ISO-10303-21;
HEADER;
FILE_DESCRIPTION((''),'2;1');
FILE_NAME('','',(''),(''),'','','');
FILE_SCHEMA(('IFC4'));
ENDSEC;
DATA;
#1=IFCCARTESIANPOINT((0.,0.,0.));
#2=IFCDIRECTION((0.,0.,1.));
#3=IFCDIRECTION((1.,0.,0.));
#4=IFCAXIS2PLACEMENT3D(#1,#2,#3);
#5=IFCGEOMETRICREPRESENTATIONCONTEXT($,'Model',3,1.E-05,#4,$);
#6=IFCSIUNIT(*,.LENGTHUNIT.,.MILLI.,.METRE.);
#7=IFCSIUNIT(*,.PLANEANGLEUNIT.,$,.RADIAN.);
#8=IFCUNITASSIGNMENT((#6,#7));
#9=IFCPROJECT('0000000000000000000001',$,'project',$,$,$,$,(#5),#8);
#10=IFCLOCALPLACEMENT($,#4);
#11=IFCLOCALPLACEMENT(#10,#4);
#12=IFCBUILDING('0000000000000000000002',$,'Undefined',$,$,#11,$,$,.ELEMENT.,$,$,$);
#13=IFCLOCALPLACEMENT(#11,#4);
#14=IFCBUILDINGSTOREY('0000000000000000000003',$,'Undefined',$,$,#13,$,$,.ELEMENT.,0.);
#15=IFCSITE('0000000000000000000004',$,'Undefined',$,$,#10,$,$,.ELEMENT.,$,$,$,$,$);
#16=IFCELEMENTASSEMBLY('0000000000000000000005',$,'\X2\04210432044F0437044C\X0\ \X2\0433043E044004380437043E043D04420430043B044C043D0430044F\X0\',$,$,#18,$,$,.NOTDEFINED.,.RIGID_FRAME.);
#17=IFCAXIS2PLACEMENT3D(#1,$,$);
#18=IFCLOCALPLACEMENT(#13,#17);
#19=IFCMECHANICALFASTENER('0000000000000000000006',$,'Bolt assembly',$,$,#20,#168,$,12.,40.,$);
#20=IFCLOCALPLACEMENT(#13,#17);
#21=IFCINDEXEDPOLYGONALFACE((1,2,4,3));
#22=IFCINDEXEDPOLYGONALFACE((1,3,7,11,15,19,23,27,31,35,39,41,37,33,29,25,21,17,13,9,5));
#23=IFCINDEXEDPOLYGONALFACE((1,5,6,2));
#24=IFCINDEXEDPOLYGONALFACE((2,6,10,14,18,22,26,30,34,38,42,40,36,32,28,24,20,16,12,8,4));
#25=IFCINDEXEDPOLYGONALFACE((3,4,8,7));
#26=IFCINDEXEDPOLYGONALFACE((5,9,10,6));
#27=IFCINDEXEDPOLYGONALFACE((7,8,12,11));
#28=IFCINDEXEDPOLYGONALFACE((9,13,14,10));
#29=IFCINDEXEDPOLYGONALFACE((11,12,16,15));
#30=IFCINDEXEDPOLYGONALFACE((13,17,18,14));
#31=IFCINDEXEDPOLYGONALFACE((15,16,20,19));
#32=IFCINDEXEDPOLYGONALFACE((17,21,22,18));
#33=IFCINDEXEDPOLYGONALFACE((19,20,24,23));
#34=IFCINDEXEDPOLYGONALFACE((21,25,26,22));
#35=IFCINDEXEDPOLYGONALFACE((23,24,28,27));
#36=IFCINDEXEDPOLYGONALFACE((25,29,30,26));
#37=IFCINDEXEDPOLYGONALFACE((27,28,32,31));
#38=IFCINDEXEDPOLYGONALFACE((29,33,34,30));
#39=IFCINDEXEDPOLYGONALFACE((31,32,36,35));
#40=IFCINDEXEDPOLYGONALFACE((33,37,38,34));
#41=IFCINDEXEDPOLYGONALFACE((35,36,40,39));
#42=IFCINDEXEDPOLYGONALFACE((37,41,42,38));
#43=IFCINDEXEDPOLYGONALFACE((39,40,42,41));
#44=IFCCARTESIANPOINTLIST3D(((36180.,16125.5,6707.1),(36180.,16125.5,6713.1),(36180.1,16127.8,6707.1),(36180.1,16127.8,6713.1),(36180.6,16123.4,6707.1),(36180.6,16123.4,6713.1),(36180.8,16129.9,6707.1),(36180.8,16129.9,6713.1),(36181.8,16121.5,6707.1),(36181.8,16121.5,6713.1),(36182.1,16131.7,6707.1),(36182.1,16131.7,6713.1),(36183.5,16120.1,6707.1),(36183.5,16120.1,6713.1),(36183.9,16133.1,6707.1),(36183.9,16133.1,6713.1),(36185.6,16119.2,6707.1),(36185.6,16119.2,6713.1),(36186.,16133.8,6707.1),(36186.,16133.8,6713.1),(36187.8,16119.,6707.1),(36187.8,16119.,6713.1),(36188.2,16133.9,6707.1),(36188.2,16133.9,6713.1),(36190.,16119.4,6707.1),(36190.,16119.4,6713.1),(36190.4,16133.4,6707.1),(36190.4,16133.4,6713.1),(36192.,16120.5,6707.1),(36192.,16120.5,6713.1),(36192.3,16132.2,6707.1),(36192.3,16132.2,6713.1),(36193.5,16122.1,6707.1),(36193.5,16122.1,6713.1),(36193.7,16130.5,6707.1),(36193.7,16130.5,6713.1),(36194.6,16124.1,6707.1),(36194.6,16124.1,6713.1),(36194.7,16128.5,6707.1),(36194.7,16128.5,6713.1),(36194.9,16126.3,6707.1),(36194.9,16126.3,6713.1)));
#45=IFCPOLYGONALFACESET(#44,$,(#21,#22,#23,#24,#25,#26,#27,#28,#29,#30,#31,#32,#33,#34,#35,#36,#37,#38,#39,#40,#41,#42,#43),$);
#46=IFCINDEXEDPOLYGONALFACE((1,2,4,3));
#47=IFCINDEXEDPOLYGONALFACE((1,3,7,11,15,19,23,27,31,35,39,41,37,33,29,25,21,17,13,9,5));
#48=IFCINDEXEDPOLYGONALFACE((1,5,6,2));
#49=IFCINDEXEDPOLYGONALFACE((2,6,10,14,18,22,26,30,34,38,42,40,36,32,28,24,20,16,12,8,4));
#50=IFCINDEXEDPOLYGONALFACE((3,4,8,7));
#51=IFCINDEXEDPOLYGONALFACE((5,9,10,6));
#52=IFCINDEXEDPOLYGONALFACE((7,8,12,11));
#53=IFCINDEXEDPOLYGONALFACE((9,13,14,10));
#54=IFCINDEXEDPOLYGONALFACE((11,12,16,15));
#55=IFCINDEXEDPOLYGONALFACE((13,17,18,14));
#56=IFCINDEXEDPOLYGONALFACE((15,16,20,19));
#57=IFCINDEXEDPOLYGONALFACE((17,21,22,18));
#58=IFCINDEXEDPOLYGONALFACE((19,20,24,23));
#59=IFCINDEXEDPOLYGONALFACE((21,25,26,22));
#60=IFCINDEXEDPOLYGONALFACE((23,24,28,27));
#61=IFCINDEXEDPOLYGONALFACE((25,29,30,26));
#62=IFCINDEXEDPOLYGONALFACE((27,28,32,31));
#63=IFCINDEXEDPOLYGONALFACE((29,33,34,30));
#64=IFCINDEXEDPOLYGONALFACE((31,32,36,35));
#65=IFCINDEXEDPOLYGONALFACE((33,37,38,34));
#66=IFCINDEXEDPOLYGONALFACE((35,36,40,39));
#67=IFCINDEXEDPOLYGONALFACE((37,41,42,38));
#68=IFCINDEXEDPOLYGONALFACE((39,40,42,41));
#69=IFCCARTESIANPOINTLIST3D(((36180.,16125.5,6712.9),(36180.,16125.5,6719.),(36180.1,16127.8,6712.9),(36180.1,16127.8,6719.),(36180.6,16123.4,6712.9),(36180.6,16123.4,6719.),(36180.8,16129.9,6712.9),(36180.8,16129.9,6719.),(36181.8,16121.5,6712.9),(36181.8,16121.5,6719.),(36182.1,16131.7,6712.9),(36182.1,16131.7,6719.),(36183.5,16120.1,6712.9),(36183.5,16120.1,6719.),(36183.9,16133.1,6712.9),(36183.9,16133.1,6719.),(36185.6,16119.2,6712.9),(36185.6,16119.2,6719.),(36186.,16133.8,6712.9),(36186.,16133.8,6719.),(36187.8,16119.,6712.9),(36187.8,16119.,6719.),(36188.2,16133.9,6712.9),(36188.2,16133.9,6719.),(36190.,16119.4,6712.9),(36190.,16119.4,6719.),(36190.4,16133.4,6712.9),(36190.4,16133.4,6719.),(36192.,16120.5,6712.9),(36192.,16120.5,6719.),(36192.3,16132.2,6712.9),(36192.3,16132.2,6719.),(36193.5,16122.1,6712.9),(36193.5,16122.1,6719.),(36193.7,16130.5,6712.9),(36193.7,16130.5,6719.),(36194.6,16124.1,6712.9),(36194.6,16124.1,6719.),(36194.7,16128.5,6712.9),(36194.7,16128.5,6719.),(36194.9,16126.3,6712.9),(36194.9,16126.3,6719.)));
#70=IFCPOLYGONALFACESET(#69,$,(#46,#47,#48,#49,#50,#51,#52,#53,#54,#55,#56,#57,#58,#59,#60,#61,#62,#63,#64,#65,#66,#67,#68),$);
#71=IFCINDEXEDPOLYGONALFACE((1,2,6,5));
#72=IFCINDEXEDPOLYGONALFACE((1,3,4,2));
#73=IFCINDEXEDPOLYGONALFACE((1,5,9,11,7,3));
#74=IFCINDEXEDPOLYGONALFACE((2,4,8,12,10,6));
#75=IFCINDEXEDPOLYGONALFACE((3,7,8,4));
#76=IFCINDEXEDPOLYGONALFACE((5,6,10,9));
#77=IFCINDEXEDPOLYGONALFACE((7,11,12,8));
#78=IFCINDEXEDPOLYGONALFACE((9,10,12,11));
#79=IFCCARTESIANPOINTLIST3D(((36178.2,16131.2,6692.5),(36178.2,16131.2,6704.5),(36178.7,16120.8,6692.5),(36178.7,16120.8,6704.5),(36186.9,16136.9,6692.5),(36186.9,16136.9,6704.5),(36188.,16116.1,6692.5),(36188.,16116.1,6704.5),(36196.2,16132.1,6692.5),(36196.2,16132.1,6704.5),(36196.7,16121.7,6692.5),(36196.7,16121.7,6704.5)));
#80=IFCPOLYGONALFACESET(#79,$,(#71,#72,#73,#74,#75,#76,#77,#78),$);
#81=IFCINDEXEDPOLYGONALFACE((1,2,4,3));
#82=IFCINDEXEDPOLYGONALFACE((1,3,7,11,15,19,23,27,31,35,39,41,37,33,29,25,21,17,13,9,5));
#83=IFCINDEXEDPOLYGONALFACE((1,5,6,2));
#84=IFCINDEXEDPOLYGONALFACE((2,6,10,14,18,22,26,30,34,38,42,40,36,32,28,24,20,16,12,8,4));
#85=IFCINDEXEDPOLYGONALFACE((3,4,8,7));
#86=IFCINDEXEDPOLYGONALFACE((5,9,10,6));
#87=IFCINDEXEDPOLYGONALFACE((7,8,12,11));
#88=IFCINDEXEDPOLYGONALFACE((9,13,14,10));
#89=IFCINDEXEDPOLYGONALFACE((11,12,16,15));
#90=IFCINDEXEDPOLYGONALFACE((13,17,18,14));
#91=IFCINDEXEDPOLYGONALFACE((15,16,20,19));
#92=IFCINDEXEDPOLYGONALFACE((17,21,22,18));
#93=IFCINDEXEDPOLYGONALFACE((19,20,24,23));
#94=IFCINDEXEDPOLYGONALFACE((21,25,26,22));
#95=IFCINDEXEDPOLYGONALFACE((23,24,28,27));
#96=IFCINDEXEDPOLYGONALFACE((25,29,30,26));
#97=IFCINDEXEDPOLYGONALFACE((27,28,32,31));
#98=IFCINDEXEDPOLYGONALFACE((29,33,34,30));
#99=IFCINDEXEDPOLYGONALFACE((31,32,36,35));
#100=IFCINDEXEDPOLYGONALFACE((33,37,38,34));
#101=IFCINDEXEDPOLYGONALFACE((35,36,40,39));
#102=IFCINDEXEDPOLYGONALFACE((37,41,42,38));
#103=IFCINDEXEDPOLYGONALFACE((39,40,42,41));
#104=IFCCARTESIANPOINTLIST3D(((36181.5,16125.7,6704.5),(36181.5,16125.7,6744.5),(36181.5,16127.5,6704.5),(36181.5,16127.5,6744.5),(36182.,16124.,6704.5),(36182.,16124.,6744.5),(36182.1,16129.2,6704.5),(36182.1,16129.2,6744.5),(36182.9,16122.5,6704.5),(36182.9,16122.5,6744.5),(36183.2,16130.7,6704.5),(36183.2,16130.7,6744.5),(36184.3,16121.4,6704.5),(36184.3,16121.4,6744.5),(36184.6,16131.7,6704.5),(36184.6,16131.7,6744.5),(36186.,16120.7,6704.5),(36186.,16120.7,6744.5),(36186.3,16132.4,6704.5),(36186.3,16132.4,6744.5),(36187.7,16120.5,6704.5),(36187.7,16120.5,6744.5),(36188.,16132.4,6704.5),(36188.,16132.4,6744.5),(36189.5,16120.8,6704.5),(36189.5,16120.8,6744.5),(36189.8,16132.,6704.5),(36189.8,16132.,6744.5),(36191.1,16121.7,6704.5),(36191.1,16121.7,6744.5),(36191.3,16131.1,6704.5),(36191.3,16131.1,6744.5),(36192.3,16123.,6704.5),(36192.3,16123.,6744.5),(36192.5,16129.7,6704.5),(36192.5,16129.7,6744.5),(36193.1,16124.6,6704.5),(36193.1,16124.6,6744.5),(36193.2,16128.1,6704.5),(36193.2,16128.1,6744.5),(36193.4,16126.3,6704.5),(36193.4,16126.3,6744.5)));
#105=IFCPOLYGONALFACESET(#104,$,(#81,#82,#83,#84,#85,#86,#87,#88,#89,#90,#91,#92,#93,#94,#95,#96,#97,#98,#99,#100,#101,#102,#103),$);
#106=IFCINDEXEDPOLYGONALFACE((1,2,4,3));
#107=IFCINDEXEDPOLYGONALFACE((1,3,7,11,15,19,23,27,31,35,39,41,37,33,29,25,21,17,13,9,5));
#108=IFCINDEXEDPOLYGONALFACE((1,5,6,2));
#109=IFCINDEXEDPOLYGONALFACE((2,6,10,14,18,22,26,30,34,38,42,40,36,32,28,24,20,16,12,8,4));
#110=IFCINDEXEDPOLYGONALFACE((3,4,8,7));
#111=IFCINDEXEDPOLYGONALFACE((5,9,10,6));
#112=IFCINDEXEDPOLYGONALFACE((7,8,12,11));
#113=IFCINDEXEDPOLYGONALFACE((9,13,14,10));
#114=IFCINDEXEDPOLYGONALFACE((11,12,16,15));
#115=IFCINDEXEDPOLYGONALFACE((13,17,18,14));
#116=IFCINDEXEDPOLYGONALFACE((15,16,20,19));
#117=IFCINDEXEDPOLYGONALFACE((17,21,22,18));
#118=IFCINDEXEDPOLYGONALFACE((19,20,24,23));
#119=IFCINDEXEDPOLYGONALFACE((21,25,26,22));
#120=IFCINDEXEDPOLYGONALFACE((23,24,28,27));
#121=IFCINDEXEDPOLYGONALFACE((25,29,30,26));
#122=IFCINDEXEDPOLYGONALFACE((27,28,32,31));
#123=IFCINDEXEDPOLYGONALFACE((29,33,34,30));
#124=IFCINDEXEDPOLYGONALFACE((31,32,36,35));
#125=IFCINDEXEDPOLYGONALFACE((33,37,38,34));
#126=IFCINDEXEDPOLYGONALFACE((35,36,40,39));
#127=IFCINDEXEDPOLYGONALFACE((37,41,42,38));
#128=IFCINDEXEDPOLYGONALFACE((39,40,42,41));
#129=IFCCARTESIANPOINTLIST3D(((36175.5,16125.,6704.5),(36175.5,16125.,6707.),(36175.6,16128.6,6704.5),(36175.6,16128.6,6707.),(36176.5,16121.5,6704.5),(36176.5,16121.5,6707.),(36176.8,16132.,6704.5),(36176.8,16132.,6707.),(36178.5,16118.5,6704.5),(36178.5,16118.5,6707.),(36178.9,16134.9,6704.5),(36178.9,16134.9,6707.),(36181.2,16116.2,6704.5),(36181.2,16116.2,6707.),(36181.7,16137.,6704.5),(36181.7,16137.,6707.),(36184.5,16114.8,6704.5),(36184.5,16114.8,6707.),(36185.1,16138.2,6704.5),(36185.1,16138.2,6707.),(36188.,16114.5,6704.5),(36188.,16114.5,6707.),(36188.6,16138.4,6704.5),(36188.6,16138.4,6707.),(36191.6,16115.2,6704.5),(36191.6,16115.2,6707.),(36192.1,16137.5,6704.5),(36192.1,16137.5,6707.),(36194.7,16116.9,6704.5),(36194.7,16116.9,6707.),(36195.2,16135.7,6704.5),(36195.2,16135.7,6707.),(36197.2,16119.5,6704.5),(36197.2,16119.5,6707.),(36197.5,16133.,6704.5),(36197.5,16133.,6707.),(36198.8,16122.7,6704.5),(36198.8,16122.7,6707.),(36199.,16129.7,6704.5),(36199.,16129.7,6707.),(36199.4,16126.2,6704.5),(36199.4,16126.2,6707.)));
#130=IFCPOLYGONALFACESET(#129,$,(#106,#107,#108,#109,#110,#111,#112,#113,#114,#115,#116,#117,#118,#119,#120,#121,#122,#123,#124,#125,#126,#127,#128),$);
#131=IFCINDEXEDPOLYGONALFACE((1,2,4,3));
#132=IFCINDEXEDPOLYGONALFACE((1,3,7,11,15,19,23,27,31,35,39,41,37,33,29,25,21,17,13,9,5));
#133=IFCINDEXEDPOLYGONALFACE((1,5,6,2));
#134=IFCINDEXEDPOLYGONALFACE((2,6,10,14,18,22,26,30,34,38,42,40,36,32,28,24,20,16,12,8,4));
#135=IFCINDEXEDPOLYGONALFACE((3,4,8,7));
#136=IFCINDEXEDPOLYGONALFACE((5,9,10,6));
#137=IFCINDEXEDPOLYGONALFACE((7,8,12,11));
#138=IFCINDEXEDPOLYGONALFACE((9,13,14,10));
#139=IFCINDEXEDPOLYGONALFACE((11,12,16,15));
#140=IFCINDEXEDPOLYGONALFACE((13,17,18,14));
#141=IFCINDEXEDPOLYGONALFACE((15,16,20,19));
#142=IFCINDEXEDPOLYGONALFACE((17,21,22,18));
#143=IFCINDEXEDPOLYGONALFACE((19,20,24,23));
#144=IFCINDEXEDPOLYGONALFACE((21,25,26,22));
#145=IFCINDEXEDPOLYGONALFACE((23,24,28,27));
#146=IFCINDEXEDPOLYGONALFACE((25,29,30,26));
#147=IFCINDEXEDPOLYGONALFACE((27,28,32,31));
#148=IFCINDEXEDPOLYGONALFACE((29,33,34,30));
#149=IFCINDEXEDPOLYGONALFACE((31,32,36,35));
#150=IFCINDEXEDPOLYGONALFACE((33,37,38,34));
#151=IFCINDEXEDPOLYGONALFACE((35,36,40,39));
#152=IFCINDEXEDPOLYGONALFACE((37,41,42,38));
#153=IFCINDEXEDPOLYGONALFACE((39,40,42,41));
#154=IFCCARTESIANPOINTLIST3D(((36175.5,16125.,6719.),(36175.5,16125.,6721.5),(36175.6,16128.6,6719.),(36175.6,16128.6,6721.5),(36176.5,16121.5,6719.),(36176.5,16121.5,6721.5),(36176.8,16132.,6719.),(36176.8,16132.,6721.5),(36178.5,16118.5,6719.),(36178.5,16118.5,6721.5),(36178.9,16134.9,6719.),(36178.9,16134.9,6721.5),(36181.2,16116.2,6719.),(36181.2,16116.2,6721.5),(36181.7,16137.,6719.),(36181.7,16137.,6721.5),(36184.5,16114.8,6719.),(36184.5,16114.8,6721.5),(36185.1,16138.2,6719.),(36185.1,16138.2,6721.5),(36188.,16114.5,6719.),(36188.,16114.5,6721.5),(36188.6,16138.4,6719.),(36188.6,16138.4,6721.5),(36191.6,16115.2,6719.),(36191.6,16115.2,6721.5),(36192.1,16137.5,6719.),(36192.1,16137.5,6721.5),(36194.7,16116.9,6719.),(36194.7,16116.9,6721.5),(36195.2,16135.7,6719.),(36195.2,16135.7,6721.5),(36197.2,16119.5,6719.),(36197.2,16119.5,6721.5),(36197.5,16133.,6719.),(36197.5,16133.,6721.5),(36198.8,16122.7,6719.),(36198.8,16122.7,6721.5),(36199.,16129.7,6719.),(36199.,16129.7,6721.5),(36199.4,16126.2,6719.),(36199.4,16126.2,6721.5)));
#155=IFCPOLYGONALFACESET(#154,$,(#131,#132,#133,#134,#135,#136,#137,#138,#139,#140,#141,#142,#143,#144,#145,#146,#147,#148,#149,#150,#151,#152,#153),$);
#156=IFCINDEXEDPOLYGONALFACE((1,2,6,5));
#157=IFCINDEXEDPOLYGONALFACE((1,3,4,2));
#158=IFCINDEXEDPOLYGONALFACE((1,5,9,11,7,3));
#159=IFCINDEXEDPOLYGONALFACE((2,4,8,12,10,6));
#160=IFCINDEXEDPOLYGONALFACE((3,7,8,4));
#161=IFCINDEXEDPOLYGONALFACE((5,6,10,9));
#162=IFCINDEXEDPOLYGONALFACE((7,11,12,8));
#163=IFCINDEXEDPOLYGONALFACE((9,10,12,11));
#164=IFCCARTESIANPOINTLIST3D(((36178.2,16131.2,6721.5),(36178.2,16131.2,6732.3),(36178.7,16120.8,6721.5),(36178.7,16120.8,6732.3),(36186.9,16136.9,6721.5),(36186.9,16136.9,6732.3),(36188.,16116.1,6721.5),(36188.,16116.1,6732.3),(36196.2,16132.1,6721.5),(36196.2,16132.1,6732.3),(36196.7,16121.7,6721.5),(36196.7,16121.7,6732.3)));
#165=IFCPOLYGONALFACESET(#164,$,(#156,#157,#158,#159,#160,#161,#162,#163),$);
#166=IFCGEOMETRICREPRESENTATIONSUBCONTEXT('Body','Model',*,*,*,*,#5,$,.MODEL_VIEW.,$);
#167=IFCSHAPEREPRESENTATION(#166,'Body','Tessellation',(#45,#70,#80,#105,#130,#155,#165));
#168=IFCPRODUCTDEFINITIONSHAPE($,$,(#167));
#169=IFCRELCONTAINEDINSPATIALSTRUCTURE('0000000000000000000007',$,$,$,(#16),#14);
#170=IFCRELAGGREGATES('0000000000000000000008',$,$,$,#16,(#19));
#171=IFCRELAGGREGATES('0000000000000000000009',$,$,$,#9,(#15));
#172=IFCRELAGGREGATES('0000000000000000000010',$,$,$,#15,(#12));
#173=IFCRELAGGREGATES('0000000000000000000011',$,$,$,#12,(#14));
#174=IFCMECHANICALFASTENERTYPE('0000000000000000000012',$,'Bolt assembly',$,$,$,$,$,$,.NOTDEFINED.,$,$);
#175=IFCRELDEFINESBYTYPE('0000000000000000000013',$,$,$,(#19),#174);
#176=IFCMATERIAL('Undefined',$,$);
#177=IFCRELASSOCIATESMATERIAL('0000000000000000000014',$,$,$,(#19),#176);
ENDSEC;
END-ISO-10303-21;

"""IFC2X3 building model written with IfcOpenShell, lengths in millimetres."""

from ifc_helpers import new_model, si_unit, frame, origin_with_axes, origin_2d_with_axis, place, context, subcontext, project, spatial, polyline, circle, outline, extrude, source, transform, mapped, material, type_object, element, aggregate, save


model = new_model("IFC2X3")

# Units and contexts
model_context = context("Model", 3, precision=1e-05, world=origin_with_axes())
body_context = subcontext(model_context, "Body", "Model", "MODEL_VIEW")
ifc_project = project(units=[si_unit("LENGTHUNIT", "METRE", prefix="MILLI"), si_unit("PLANEANGLEUNIT", "RADIAN")], contexts=[model_context])

# Site, building, storey
site_placement = place(None, origin_with_axes())
site = spatial("IfcSite", under=ifc_project, at=site_placement, Name="Undefined", CompositionType="ELEMENT")
building_placement = place(site_placement, origin_with_axes())
building = spatial("IfcBuilding", under=site, at=building_placement, Name="Undefined", CompositionType="ELEMENT")
storey_placement = place(building_placement, origin_with_axes())
storey = spatial("IfcBuildingStorey", under=building, at=storey_placement, Name="Undefined", CompositionType="ELEMENT", Elevation=0.0)

# Element assembly
assembly_1_placement = place(storey_placement, origin_with_axes())
assembly_1 = element("IfcElementAssembly", 1, at=assembly_1_placement, inside=storey, Name="Связь горизонтальная", AssemblyPlace="NOTDEFINED", PredefinedType="RIGID_FRAME")

# Mechanical fastener
ifc_material_1 = material(Name="Undefined")
mechanical_fastener_type = type_object("IfcMechanicalFastenerType", Name="Bolt assembly")
shared_shape_1 = source(origin_with_axes(), body_context, "Body", "SweptSolid", [
    extrude(circle(Radius=7.5, at=origin_2d_with_axis()), frame((0.0, 0.1, 0.0), z_axis=(0.0, 1.0, 0.0), x_axis=(1.0, 0.0, 0.0)), (0.0, 0.0, 1.0), 6.0),
    extrude(circle(Radius=7.5, at=origin_2d_with_axis()), frame((0.0, 5.9, 0.0), z_axis=(0.0, 1.0, 0.0), x_axis=(1.0, 0.0, 0.0)), (0.0, 0.0, 1.0), 6.1),
    extrude(outline(polyline([(10.4, 0.0), (5.2, 9.0), (-5.2, 9.0), (-10.4, 0.0), (-5.2, -9.0), (5.2, -9.0), (10.4, 0.0)])), frame((0.0, -14.5, 0.0), z_axis=(0.0, 1.0, 0.0), x_axis=(1.0, 0.0, 0.0)), (0.0, 0.0, 1.0), 12.0),
    extrude(circle(Radius=6.0, at=origin_2d_with_axis()), frame((0.0, -2.5, 0.0), z_axis=(0.0, 1.0, 0.0), x_axis=(1.0, 0.0, 0.0)), (0.0, 0.0, 1.0), 40.0),
    extrude(circle(Radius=12.0, at=origin_2d_with_axis()), frame((0.0, -2.5, 0.0), z_axis=(0.0, 1.0, 0.0), x_axis=(1.0, 0.0, 0.0)), (0.0, 0.0, 1.0), 2.5),
    extrude(circle(Radius=12.0, at=origin_2d_with_axis()), frame((0.0, 12.0, 0.0), z_axis=(0.0, 1.0, 0.0), x_axis=(1.0, 0.0, 0.0)), (0.0, 0.0, 1.0), 2.5),
    extrude(outline(polyline([(10.4, 0.0), (5.2, 9.0), (-5.2, 9.0), (-10.4, 0.0), (-5.2, -9.0), (5.2, -9.0), (10.4, 0.0)])), frame((0.0, 14.5, 0.0), z_axis=(0.0, 1.0, 0.0), x_axis=(1.0, 0.0, 0.0)), (0.0, 0.0, 1.0), 10.8),
])
mechanical_fastener_1_placement = place(assembly_1_placement, frame((36187.4, 16126.5, 6707.0), z_axis=(0.542525, -0.840039, 0.0), x_axis=(0.840039, 0.542525, 0.0)))
mechanical_fastener_1 = element("IfcMechanicalFastener", 2, at=mechanical_fastener_1_placement, type_object=mechanical_fastener_type, material=ifc_material_1, Name="Bolt assembly", NominalDiameter=12.0, NominalLength=40.0, context=body_context, shape_type="MappedRepresentation", body=[
    mapped(shared_shape_1, transform((0.0, 0.0, 0.0))),
])
aggregate(assembly_1, [mechanical_fastener_1])

save(model, "model.ifc")
